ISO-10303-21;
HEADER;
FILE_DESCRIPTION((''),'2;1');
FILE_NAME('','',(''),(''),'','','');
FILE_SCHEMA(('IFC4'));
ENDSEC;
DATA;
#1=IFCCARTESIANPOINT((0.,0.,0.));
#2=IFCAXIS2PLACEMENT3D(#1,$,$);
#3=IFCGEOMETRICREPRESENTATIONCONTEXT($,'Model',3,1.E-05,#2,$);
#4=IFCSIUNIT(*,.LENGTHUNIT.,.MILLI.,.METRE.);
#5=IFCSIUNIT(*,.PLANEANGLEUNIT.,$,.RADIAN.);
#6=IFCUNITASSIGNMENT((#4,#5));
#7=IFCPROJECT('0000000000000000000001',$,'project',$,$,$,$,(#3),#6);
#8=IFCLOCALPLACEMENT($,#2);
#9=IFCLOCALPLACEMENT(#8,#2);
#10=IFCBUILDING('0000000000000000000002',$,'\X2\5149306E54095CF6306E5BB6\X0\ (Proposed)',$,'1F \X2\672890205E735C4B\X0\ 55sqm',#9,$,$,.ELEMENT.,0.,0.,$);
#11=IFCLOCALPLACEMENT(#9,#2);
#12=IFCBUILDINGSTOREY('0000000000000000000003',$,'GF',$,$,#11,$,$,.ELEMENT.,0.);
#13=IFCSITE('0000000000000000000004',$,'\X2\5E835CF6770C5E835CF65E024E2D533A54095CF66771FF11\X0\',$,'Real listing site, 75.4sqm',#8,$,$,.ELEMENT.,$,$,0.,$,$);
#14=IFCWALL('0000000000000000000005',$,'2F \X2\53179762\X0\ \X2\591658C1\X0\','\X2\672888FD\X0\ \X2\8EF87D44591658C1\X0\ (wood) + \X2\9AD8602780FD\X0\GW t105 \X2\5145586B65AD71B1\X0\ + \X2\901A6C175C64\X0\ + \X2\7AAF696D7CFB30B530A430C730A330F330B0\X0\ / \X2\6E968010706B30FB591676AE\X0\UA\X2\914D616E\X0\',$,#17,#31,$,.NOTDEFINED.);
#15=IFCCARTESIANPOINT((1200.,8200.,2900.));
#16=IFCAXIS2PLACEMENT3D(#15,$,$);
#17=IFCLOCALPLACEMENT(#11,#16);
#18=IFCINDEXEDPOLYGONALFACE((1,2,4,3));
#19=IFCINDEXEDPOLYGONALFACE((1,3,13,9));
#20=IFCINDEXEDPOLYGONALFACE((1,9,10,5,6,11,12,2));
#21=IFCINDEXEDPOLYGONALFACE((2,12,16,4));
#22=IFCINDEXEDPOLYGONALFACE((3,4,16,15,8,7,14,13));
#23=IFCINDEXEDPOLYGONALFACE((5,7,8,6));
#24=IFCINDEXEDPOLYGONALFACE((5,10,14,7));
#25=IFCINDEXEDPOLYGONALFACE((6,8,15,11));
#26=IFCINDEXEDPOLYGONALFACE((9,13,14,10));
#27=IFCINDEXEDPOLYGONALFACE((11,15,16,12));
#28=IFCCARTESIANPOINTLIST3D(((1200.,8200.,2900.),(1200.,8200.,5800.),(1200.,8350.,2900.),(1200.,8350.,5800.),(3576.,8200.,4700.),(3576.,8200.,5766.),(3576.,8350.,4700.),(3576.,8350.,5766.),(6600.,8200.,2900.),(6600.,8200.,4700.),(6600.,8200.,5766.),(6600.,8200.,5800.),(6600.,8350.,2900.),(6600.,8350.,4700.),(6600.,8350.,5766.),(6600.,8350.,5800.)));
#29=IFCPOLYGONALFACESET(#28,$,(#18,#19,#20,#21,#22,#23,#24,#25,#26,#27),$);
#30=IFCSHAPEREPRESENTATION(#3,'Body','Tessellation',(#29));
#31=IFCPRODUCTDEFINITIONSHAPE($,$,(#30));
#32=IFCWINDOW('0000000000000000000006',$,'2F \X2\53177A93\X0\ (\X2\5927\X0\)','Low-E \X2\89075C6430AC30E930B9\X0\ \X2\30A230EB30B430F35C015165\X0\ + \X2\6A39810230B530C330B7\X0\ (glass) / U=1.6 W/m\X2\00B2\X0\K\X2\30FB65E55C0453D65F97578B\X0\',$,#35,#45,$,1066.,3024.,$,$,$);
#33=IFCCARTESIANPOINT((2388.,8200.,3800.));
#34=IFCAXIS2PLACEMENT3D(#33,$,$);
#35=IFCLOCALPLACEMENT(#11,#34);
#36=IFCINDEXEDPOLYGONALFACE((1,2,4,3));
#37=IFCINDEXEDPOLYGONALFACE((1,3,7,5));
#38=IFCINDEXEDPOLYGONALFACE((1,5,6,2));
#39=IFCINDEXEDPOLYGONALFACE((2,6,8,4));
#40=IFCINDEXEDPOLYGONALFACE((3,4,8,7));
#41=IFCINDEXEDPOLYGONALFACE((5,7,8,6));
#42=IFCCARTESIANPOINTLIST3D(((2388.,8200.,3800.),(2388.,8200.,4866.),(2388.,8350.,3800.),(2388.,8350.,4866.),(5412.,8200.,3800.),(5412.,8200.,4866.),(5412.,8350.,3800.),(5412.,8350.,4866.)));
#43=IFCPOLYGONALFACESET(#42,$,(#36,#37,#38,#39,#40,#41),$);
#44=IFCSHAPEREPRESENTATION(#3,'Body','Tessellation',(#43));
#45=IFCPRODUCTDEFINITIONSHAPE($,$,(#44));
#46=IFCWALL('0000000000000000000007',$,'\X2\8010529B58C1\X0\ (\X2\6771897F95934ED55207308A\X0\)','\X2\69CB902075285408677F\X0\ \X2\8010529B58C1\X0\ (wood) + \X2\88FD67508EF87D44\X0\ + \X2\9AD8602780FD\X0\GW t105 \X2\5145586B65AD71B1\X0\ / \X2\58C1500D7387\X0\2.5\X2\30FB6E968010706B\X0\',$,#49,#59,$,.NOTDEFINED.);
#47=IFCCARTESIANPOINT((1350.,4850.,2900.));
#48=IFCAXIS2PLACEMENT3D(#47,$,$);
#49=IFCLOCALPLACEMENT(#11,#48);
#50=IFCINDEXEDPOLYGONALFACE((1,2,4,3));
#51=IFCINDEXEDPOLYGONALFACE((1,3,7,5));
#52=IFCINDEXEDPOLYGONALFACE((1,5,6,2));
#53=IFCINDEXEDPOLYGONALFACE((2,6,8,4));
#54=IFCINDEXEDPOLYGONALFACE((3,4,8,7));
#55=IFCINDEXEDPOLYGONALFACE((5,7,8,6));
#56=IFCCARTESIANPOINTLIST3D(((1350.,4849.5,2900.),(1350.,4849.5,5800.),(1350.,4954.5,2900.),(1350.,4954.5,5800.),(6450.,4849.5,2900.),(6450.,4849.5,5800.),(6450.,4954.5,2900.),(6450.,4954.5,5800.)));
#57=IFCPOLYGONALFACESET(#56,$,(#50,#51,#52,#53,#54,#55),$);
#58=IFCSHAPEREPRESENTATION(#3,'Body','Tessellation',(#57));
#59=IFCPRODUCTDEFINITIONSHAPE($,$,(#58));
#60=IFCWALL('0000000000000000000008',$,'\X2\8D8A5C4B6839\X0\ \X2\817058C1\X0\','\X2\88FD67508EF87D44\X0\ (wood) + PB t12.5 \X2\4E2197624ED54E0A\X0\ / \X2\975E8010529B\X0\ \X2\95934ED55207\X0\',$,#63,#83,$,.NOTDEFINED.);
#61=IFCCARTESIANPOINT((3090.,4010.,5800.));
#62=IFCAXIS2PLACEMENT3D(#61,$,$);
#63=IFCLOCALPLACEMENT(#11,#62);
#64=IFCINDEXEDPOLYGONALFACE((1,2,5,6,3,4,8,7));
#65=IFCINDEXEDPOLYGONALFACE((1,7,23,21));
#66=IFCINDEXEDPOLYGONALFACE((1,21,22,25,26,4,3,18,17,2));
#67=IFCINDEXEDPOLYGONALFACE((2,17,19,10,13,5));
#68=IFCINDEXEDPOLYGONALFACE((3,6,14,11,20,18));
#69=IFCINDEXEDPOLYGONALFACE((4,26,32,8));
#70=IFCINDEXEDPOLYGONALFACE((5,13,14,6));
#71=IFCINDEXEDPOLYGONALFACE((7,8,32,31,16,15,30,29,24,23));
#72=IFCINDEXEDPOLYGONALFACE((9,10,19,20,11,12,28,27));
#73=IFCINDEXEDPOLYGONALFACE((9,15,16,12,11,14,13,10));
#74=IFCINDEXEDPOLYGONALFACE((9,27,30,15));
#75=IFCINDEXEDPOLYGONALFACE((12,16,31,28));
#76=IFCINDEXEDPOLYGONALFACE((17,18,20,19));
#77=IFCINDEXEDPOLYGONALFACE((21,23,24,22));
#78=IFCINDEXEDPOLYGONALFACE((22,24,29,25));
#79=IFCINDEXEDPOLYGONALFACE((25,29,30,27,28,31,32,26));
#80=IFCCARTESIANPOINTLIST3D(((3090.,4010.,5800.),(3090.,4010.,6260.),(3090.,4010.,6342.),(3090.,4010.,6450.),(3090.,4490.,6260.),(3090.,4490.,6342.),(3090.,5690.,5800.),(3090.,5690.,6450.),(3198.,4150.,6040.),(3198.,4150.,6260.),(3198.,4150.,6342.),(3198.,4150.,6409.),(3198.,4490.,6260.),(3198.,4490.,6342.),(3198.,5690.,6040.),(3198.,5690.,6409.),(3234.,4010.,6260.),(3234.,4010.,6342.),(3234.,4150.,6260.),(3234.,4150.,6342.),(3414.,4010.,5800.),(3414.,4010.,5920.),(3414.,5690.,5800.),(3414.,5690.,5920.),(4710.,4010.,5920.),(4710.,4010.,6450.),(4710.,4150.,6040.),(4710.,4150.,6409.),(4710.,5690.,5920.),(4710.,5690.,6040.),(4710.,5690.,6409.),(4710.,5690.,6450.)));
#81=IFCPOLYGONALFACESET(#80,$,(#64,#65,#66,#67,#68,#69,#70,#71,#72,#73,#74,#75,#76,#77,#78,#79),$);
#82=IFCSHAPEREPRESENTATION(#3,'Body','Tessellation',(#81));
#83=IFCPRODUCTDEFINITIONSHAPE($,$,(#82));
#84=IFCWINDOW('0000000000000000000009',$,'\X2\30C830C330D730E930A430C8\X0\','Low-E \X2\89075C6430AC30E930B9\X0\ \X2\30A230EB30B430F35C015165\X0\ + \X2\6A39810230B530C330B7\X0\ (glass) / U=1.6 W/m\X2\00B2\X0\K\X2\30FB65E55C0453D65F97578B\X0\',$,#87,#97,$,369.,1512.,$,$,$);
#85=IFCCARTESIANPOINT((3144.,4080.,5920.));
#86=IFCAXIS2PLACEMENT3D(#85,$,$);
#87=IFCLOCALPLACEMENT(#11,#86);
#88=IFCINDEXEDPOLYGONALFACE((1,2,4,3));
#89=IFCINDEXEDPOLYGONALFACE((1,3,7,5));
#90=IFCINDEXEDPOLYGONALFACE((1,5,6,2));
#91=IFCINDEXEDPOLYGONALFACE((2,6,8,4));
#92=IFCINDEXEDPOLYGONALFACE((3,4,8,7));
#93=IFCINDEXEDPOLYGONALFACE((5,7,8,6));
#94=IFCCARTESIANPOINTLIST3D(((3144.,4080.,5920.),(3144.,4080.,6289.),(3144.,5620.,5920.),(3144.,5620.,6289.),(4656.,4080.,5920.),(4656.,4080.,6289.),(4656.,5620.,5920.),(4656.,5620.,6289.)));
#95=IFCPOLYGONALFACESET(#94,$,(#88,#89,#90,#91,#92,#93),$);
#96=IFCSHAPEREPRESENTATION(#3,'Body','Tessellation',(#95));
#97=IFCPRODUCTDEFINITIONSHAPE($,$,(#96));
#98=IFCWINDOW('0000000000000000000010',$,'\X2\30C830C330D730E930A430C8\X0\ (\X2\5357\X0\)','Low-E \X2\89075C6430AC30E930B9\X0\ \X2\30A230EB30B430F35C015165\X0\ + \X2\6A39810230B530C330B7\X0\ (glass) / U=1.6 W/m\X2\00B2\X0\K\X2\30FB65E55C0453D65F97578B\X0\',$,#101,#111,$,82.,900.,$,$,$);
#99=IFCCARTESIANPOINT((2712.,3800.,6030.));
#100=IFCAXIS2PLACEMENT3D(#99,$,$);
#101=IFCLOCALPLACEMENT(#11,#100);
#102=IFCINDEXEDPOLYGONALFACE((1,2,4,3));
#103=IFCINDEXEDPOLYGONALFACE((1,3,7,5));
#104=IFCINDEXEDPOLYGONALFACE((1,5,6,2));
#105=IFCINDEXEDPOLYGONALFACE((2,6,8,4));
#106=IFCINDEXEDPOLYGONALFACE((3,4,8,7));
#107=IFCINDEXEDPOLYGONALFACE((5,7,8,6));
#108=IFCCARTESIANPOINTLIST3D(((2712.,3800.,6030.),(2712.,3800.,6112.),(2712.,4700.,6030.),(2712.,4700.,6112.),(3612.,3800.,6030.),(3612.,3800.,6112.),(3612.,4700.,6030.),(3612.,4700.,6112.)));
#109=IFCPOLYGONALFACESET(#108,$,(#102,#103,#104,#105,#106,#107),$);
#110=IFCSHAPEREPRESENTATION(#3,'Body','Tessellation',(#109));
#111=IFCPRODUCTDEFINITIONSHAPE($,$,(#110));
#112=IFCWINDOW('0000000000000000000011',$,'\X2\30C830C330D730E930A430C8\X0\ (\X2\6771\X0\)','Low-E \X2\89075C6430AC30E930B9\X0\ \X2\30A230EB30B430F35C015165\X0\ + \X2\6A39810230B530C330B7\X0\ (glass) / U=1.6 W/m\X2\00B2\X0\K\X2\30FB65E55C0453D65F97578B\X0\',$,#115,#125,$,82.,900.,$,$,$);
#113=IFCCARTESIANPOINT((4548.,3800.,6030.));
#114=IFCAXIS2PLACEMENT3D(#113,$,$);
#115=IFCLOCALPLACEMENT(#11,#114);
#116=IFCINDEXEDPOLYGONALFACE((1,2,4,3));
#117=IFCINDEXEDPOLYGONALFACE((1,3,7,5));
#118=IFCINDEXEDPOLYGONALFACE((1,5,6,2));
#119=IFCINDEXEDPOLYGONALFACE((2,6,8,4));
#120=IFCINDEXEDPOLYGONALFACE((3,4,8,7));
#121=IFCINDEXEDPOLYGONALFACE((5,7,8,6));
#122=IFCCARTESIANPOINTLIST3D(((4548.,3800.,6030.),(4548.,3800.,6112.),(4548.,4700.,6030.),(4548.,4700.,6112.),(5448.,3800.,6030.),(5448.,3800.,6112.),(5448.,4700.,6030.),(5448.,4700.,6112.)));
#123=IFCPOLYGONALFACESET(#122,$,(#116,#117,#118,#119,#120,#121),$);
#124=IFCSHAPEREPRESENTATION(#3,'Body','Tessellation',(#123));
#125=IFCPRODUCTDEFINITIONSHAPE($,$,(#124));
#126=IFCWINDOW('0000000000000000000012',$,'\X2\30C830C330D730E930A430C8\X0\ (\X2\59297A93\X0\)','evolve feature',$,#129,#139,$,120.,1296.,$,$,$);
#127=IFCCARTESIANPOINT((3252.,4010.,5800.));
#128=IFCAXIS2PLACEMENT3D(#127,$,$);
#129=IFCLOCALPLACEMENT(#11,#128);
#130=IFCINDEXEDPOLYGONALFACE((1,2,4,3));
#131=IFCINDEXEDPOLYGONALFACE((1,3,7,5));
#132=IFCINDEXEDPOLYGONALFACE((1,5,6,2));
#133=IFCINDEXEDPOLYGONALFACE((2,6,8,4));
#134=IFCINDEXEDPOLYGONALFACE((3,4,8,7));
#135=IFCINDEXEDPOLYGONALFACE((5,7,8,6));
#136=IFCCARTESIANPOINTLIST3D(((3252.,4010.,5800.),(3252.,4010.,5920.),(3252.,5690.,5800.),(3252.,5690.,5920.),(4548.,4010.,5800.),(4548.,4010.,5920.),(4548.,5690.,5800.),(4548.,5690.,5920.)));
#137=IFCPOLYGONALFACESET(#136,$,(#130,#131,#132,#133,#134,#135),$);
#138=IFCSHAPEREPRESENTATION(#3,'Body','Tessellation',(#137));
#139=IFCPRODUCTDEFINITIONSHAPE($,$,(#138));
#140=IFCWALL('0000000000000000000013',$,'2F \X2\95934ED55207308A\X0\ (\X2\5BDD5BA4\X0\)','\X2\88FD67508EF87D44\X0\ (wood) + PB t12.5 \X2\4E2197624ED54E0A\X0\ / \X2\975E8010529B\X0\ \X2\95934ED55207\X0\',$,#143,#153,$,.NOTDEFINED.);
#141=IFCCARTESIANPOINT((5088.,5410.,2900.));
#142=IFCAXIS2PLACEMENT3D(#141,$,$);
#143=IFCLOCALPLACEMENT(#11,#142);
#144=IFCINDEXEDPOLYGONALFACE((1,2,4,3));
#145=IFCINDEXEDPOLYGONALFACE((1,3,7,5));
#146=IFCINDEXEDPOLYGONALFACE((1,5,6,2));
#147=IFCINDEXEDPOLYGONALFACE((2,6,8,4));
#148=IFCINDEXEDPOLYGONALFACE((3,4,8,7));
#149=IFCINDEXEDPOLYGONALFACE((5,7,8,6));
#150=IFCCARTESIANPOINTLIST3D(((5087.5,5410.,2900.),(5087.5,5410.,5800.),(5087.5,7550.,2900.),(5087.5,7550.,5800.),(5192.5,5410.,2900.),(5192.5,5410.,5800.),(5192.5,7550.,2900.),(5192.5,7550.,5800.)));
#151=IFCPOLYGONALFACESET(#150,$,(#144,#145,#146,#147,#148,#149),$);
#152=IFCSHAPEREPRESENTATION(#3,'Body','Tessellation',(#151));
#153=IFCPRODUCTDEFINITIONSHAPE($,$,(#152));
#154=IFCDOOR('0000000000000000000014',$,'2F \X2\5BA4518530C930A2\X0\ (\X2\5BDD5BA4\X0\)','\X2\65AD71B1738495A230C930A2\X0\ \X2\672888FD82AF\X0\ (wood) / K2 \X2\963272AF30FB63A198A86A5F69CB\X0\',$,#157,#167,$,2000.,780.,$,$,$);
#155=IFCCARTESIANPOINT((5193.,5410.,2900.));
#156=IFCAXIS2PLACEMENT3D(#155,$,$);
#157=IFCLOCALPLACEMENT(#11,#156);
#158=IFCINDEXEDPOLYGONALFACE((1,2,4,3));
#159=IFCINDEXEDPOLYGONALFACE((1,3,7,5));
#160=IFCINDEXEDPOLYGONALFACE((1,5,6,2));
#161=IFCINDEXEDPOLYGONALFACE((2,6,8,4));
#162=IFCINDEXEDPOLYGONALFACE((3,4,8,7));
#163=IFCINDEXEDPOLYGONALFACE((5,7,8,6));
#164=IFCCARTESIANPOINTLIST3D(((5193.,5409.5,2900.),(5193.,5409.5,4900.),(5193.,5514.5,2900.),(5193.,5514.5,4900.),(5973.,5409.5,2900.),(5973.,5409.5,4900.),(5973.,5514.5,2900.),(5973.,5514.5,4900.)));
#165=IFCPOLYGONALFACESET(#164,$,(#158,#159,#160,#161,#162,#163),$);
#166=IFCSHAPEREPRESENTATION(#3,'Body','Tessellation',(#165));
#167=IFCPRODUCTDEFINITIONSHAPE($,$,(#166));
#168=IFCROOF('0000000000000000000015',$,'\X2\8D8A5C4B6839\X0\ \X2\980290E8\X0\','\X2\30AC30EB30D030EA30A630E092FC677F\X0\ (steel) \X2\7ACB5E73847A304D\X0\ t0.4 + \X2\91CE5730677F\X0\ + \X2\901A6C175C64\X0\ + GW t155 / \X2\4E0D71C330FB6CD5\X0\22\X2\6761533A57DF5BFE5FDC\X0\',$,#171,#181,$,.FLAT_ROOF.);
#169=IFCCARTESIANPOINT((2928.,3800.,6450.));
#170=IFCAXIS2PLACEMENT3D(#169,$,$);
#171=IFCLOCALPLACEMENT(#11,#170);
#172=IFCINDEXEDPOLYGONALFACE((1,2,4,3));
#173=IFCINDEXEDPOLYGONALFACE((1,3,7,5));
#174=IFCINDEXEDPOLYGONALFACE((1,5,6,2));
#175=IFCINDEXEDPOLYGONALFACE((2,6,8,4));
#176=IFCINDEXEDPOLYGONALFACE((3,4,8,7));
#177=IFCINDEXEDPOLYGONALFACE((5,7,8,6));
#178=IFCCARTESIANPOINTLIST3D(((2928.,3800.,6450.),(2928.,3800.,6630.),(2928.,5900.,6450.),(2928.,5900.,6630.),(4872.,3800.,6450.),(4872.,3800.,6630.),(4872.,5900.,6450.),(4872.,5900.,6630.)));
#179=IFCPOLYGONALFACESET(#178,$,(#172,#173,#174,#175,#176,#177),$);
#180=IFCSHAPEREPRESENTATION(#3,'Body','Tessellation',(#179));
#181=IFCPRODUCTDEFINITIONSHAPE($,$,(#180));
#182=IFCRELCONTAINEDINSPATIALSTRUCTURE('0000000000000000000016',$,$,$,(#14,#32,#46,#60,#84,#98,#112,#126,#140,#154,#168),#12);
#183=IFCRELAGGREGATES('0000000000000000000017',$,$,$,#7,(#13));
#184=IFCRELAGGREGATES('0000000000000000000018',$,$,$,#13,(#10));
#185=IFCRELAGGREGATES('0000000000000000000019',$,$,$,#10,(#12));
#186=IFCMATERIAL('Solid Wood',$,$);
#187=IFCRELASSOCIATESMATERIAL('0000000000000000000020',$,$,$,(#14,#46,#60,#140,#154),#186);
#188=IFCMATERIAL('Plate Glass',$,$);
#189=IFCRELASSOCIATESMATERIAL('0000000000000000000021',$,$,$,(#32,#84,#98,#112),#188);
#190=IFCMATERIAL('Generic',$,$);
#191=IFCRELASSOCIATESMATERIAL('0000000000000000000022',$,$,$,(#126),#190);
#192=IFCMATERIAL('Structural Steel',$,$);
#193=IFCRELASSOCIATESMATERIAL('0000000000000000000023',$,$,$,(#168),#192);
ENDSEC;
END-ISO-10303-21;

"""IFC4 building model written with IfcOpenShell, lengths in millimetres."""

from ifc_helpers import new_model, si_unit, frame, frame_2d, origin, place, context, project, spatial, rectangle, extrude, material, element, fill, save


model = new_model("IFC4")

# Units and contexts
model_context = context("Model", 3, precision=1e-05, world=origin())
ifc_project = project(units=[si_unit("LENGTHUNIT", "METRE", prefix="MILLI"), si_unit("PLANEANGLEUNIT", "RADIAN")], contexts=[model_context])

# Site, building, storey
site_placement = place(None, origin())
site = spatial("IfcSite", under=ifc_project, at=site_placement, Name="広島県広島市中区吉島東１", ObjectType="Real listing site, 75.4sqm", CompositionType="ELEMENT", RefElevation=0.0)
building_placement = place(site_placement, origin())
building = spatial("IfcBuilding", under=site, at=building_placement, Name="光の吉島の家 (Proposed)", ObjectType="1F 木造平屋 55sqm", CompositionType="ELEMENT", ElevationOfRefHeight=0.0, ElevationOfTerrain=0.0)
storey_placement = place(building_placement, origin())
storey = spatial("IfcBuildingStorey", under=building, at=storey_placement, Name="GF", CompositionType="ELEMENT", Elevation=0.0)

# Wall, opening, window
ifc_material_1 = material(Name="Solid Wood")
wall_1_placement = place(storey_placement, frame((1200.0, 8200.0, 2900.0)))
wall_1 = element("IfcWall", 1, at=wall_1_placement, inside=storey, material=ifc_material_1, Name="2F 北面 外壁", Description="木製 軸組外壁 (wood) + 高性能GW t105 充填断熱 + 通気層 + 窯業系サイディング / 準耐火・外皮UA配慮", PredefinedType="NOTDEFINED", context=model_context, shape_type="SweptSolid", body=[
    extrude(rectangle(XDim=5400.0, YDim=150.0, at=frame_2d((2700.0, 75.0))), frame((1200.0, 8200.0, 2900.0)), (0.0, 0.0, 1.0), 2900.0),
])
opening_1_placement = place(storey_placement, frame((2388.0, 8200.0, 3800.0)))
opening_1 = element("IfcOpeningElement", 2, at=opening_1_placement, cuts=wall_1, PredefinedType="NOTDEFINED", context=model_context, shape_type="SweptSolid", body=[
    extrude(rectangle(XDim=3024.0, YDim=150.0, at=frame_2d((1512.0, 75.0))), frame((2388.0, 8200.0, 3800.0)), (0.0, 0.0, 1.0), 1066.0),
])
ifc_material_2 = material(Name="Plate Glass")
window_1_placement = place(storey_placement, frame((2388.0, 8200.0, 3800.0)))
window_1 = element("IfcWindow", 3, at=window_1_placement, inside=storey, material=ifc_material_2, Name="2F 北窓 (大)", Description="Low-E 複層ガラス アルゴン封入 + 樹脂サッシ (glass) / U=1.6 W/m²K・日射取得型", OverallHeight=1066.0, OverallWidth=3024.0, context=model_context, shape_type="SweptSolid", body=[
    extrude(rectangle(XDim=3024.0, YDim=150.0, at=frame_2d((1512.0, 75.0))), frame((2388.0, 8200.0, 3800.0)), (0.0, 0.0, 1.0), 1066.0),
])
fill(opening_1, window_1)

# Wall
wall_2_placement = place(storey_placement, frame((1350.0, 4850.0, 2900.0)))
element("IfcWall", 4, at=wall_2_placement, inside=storey, material=ifc_material_1, Name="耐力壁 (東西間仕切り)", Description="構造用合板 耐力壁 (wood) + 製材軸組 + 高性能GW t105 充填断熱 / 壁倍率2.5・準耐火", PredefinedType="NOTDEFINED", context=model_context, shape_type="SweptSolid", body=[
    extrude(rectangle(XDim=5100.0, YDim=105.0, at=frame_2d((2550.0, 52.0))), frame((1350.0, 4850.0, 2900.0)), (0.0, 0.0, 1.0), 2900.0),
])

# Wall, openings, windows
wall_3_placement = place(storey_placement, frame((3090.0, 4010.0, 5800.0)))
wall_3 = element("IfcWall", 5, at=wall_3_placement, inside=storey, material=ifc_material_1, Name="越屋根 腰壁", Description="製材軸組 (wood) + PB t12.5 両面仕上 / 非耐力 間仕切", PredefinedType="NOTDEFINED", context=model_context, shape_type="SweptSolid", body=[
    extrude(rectangle(XDim=1620.0, YDim=1680.0, at=frame_2d((810.0, 840.0))), frame((3090.0, 4010.0, 5800.0)), (0.0, 0.0, 1.0), 650.0),
])
opening_2_placement = place(storey_placement, frame((3144.0, 4080.0, 5920.0)))
opening_2 = element("IfcOpeningElement", 6, at=opening_2_placement, cuts=wall_3, PredefinedType="NOTDEFINED", context=model_context, shape_type="SweptSolid", body=[
    extrude(rectangle(XDim=1512.0, YDim=1540.0, at=frame_2d((756.0, 770.0))), frame((3144.0, 4080.0, 5920.0)), (0.0, 0.0, 1.0), 369.0),
])
opening_3_placement = place(storey_placement, frame((2712.0, 3800.0, 6030.0)))
opening_3 = element("IfcOpeningElement", 7, at=opening_3_placement, cuts=wall_3, PredefinedType="NOTDEFINED", context=model_context, shape_type="SweptSolid", body=[
    extrude(rectangle(XDim=900.0, YDim=900.0, at=frame_2d((450.0, 450.0))), frame((2712.0, 3800.0, 6030.0)), (0.0, 0.0, 1.0), 82.0),
])
opening_4_placement = place(storey_placement, frame((4548.0, 3800.0, 6030.0)))
opening_4 = element("IfcOpeningElement", 8, at=opening_4_placement, cuts=wall_3, PredefinedType="NOTDEFINED", context=model_context, shape_type="SweptSolid", body=[
    extrude(rectangle(XDim=900.0, YDim=900.0, at=frame_2d((450.0, 450.0))), frame((4548.0, 3800.0, 6030.0)), (0.0, 0.0, 1.0), 82.0),
])
opening_5_placement = place(storey_placement, frame((3252.0, 4010.0, 5800.0)))
opening_5 = element("IfcOpeningElement", 9, at=opening_5_placement, cuts=wall_3, PredefinedType="NOTDEFINED", context=model_context, shape_type="SweptSolid", body=[
    extrude(rectangle(XDim=1296.0, YDim=1680.0, at=frame_2d((648.0, 840.0))), frame((3252.0, 4010.0, 5800.0)), (0.0, 0.0, 1.0), 120.0),
])
window_2_placement = place(storey_placement, frame((3144.0, 4080.0, 5920.0)))
window_2 = element("IfcWindow", 10, at=window_2_placement, inside=storey, material=ifc_material_2, Name="トップライト", Description="Low-E 複層ガラス アルゴン封入 + 樹脂サッシ (glass) / U=1.6 W/m²K・日射取得型", OverallHeight=369.0, OverallWidth=1512.0, context=model_context, shape_type="SweptSolid", body=[
    extrude(rectangle(XDim=1512.0, YDim=1540.0, at=frame_2d((756.0, 770.0))), frame((3144.0, 4080.0, 5920.0)), (0.0, 0.0, 1.0), 369.0),
])
fill(opening_2, window_2)
window_3_placement = place(storey_placement, frame((2712.0, 3800.0, 6030.0)))
window_3 = element("IfcWindow", 11, at=window_3_placement, inside=storey, material=ifc_material_2, Name="トップライト (南)", Description="Low-E 複層ガラス アルゴン封入 + 樹脂サッシ (glass) / U=1.6 W/m²K・日射取得型", OverallHeight=82.0, OverallWidth=900.0, context=model_context, shape_type="SweptSolid", body=[
    extrude(rectangle(XDim=900.0, YDim=900.0, at=frame_2d((450.0, 450.0))), frame((2712.0, 3800.0, 6030.0)), (0.0, 0.0, 1.0), 82.0),
])
fill(opening_3, window_3)
window_4_placement = place(storey_placement, frame((4548.0, 3800.0, 6030.0)))
window_4 = element("IfcWindow", 12, at=window_4_placement, inside=storey, material=ifc_material_2, Name="トップライト (東)", Description="Low-E 複層ガラス アルゴン封入 + 樹脂サッシ (glass) / U=1.6 W/m²K・日射取得型", OverallHeight=82.0, OverallWidth=900.0, context=model_context, shape_type="SweptSolid", body=[
    extrude(rectangle(XDim=900.0, YDim=900.0, at=frame_2d((450.0, 450.0))), frame((4548.0, 3800.0, 6030.0)), (0.0, 0.0, 1.0), 82.0),
])
fill(opening_4, window_4)
ifc_material_3 = material(Name="Generic")
window_5_placement = place(storey_placement, frame((3252.0, 4010.0, 5800.0)))
window_5 = element("IfcWindow", 13, at=window_5_placement, inside=storey, material=ifc_material_3, Name="トップライト (天窓)", Description="evolve feature", OverallHeight=120.0, OverallWidth=1296.0, context=model_context, shape_type="SweptSolid", body=[
    extrude(rectangle(XDim=1296.0, YDim=1680.0, at=frame_2d((648.0, 840.0))), frame((3252.0, 4010.0, 5800.0)), (0.0, 0.0, 1.0), 120.0),
])
fill(opening_5, window_5)

# Wall
wall_4_placement = place(storey_placement, frame((5088.0, 5410.0, 2900.0)))
element("IfcWall", 14, at=wall_4_placement, inside=storey, material=ifc_material_1, Name="2F 間仕切り (寝室)", Description="製材軸組 (wood) + PB t12.5 両面仕上 / 非耐力 間仕切", PredefinedType="NOTDEFINED", context=model_context, shape_type="SweptSolid", body=[
    extrude(rectangle(XDim=105.0, YDim=2140.0, at=frame_2d((52.0, 1070.0))), frame((5088.0, 5410.0, 2900.0)), (0.0, 0.0, 1.0), 2900.0),
])

# Door
door_placement = place(storey_placement, frame((5193.0, 5410.0, 2900.0)))
element("IfcDoor", 15, at=door_placement, inside=storey, material=ifc_material_1, Name="2F 室内ドア (寝室)", Description="断熱玄関ドア 木製芯 (wood) / K2 防犯・採風機構", OverallHeight=2000.0, OverallWidth=780.0, context=model_context, shape_type="SweptSolid", body=[
    extrude(rectangle(XDim=780.0, YDim=105.0, at=frame_2d((390.0, 52.0))), frame((5193.0, 5410.0, 2900.0)), (0.0, 0.0, 1.0), 2000.0),
])

# Roof
ifc_material_4 = material(Name="Structural Steel")
roof_placement = place(storey_placement, frame((2928.0, 3800.0, 6450.0)))
element("IfcRoof", 16, at=roof_placement, inside=storey, material=ifc_material_4, Name="越屋根 頂部", Description="ガルバリウム鋼板 (steel) 立平葺き t0.4 + 野地板 + 通気層 + GW t155 / 不燃・法22条区域対応", PredefinedType="FLAT_ROOF", context=model_context, shape_type="SweptSolid", body=[
    extrude(rectangle(XDim=1944.0, YDim=2100.0, at=frame_2d((972.0, 1050.0))), frame((2928.0, 3800.0, 6450.0)), (0.0, 0.0, 1.0), 180.0),
])

save(model, "model.ifc")
